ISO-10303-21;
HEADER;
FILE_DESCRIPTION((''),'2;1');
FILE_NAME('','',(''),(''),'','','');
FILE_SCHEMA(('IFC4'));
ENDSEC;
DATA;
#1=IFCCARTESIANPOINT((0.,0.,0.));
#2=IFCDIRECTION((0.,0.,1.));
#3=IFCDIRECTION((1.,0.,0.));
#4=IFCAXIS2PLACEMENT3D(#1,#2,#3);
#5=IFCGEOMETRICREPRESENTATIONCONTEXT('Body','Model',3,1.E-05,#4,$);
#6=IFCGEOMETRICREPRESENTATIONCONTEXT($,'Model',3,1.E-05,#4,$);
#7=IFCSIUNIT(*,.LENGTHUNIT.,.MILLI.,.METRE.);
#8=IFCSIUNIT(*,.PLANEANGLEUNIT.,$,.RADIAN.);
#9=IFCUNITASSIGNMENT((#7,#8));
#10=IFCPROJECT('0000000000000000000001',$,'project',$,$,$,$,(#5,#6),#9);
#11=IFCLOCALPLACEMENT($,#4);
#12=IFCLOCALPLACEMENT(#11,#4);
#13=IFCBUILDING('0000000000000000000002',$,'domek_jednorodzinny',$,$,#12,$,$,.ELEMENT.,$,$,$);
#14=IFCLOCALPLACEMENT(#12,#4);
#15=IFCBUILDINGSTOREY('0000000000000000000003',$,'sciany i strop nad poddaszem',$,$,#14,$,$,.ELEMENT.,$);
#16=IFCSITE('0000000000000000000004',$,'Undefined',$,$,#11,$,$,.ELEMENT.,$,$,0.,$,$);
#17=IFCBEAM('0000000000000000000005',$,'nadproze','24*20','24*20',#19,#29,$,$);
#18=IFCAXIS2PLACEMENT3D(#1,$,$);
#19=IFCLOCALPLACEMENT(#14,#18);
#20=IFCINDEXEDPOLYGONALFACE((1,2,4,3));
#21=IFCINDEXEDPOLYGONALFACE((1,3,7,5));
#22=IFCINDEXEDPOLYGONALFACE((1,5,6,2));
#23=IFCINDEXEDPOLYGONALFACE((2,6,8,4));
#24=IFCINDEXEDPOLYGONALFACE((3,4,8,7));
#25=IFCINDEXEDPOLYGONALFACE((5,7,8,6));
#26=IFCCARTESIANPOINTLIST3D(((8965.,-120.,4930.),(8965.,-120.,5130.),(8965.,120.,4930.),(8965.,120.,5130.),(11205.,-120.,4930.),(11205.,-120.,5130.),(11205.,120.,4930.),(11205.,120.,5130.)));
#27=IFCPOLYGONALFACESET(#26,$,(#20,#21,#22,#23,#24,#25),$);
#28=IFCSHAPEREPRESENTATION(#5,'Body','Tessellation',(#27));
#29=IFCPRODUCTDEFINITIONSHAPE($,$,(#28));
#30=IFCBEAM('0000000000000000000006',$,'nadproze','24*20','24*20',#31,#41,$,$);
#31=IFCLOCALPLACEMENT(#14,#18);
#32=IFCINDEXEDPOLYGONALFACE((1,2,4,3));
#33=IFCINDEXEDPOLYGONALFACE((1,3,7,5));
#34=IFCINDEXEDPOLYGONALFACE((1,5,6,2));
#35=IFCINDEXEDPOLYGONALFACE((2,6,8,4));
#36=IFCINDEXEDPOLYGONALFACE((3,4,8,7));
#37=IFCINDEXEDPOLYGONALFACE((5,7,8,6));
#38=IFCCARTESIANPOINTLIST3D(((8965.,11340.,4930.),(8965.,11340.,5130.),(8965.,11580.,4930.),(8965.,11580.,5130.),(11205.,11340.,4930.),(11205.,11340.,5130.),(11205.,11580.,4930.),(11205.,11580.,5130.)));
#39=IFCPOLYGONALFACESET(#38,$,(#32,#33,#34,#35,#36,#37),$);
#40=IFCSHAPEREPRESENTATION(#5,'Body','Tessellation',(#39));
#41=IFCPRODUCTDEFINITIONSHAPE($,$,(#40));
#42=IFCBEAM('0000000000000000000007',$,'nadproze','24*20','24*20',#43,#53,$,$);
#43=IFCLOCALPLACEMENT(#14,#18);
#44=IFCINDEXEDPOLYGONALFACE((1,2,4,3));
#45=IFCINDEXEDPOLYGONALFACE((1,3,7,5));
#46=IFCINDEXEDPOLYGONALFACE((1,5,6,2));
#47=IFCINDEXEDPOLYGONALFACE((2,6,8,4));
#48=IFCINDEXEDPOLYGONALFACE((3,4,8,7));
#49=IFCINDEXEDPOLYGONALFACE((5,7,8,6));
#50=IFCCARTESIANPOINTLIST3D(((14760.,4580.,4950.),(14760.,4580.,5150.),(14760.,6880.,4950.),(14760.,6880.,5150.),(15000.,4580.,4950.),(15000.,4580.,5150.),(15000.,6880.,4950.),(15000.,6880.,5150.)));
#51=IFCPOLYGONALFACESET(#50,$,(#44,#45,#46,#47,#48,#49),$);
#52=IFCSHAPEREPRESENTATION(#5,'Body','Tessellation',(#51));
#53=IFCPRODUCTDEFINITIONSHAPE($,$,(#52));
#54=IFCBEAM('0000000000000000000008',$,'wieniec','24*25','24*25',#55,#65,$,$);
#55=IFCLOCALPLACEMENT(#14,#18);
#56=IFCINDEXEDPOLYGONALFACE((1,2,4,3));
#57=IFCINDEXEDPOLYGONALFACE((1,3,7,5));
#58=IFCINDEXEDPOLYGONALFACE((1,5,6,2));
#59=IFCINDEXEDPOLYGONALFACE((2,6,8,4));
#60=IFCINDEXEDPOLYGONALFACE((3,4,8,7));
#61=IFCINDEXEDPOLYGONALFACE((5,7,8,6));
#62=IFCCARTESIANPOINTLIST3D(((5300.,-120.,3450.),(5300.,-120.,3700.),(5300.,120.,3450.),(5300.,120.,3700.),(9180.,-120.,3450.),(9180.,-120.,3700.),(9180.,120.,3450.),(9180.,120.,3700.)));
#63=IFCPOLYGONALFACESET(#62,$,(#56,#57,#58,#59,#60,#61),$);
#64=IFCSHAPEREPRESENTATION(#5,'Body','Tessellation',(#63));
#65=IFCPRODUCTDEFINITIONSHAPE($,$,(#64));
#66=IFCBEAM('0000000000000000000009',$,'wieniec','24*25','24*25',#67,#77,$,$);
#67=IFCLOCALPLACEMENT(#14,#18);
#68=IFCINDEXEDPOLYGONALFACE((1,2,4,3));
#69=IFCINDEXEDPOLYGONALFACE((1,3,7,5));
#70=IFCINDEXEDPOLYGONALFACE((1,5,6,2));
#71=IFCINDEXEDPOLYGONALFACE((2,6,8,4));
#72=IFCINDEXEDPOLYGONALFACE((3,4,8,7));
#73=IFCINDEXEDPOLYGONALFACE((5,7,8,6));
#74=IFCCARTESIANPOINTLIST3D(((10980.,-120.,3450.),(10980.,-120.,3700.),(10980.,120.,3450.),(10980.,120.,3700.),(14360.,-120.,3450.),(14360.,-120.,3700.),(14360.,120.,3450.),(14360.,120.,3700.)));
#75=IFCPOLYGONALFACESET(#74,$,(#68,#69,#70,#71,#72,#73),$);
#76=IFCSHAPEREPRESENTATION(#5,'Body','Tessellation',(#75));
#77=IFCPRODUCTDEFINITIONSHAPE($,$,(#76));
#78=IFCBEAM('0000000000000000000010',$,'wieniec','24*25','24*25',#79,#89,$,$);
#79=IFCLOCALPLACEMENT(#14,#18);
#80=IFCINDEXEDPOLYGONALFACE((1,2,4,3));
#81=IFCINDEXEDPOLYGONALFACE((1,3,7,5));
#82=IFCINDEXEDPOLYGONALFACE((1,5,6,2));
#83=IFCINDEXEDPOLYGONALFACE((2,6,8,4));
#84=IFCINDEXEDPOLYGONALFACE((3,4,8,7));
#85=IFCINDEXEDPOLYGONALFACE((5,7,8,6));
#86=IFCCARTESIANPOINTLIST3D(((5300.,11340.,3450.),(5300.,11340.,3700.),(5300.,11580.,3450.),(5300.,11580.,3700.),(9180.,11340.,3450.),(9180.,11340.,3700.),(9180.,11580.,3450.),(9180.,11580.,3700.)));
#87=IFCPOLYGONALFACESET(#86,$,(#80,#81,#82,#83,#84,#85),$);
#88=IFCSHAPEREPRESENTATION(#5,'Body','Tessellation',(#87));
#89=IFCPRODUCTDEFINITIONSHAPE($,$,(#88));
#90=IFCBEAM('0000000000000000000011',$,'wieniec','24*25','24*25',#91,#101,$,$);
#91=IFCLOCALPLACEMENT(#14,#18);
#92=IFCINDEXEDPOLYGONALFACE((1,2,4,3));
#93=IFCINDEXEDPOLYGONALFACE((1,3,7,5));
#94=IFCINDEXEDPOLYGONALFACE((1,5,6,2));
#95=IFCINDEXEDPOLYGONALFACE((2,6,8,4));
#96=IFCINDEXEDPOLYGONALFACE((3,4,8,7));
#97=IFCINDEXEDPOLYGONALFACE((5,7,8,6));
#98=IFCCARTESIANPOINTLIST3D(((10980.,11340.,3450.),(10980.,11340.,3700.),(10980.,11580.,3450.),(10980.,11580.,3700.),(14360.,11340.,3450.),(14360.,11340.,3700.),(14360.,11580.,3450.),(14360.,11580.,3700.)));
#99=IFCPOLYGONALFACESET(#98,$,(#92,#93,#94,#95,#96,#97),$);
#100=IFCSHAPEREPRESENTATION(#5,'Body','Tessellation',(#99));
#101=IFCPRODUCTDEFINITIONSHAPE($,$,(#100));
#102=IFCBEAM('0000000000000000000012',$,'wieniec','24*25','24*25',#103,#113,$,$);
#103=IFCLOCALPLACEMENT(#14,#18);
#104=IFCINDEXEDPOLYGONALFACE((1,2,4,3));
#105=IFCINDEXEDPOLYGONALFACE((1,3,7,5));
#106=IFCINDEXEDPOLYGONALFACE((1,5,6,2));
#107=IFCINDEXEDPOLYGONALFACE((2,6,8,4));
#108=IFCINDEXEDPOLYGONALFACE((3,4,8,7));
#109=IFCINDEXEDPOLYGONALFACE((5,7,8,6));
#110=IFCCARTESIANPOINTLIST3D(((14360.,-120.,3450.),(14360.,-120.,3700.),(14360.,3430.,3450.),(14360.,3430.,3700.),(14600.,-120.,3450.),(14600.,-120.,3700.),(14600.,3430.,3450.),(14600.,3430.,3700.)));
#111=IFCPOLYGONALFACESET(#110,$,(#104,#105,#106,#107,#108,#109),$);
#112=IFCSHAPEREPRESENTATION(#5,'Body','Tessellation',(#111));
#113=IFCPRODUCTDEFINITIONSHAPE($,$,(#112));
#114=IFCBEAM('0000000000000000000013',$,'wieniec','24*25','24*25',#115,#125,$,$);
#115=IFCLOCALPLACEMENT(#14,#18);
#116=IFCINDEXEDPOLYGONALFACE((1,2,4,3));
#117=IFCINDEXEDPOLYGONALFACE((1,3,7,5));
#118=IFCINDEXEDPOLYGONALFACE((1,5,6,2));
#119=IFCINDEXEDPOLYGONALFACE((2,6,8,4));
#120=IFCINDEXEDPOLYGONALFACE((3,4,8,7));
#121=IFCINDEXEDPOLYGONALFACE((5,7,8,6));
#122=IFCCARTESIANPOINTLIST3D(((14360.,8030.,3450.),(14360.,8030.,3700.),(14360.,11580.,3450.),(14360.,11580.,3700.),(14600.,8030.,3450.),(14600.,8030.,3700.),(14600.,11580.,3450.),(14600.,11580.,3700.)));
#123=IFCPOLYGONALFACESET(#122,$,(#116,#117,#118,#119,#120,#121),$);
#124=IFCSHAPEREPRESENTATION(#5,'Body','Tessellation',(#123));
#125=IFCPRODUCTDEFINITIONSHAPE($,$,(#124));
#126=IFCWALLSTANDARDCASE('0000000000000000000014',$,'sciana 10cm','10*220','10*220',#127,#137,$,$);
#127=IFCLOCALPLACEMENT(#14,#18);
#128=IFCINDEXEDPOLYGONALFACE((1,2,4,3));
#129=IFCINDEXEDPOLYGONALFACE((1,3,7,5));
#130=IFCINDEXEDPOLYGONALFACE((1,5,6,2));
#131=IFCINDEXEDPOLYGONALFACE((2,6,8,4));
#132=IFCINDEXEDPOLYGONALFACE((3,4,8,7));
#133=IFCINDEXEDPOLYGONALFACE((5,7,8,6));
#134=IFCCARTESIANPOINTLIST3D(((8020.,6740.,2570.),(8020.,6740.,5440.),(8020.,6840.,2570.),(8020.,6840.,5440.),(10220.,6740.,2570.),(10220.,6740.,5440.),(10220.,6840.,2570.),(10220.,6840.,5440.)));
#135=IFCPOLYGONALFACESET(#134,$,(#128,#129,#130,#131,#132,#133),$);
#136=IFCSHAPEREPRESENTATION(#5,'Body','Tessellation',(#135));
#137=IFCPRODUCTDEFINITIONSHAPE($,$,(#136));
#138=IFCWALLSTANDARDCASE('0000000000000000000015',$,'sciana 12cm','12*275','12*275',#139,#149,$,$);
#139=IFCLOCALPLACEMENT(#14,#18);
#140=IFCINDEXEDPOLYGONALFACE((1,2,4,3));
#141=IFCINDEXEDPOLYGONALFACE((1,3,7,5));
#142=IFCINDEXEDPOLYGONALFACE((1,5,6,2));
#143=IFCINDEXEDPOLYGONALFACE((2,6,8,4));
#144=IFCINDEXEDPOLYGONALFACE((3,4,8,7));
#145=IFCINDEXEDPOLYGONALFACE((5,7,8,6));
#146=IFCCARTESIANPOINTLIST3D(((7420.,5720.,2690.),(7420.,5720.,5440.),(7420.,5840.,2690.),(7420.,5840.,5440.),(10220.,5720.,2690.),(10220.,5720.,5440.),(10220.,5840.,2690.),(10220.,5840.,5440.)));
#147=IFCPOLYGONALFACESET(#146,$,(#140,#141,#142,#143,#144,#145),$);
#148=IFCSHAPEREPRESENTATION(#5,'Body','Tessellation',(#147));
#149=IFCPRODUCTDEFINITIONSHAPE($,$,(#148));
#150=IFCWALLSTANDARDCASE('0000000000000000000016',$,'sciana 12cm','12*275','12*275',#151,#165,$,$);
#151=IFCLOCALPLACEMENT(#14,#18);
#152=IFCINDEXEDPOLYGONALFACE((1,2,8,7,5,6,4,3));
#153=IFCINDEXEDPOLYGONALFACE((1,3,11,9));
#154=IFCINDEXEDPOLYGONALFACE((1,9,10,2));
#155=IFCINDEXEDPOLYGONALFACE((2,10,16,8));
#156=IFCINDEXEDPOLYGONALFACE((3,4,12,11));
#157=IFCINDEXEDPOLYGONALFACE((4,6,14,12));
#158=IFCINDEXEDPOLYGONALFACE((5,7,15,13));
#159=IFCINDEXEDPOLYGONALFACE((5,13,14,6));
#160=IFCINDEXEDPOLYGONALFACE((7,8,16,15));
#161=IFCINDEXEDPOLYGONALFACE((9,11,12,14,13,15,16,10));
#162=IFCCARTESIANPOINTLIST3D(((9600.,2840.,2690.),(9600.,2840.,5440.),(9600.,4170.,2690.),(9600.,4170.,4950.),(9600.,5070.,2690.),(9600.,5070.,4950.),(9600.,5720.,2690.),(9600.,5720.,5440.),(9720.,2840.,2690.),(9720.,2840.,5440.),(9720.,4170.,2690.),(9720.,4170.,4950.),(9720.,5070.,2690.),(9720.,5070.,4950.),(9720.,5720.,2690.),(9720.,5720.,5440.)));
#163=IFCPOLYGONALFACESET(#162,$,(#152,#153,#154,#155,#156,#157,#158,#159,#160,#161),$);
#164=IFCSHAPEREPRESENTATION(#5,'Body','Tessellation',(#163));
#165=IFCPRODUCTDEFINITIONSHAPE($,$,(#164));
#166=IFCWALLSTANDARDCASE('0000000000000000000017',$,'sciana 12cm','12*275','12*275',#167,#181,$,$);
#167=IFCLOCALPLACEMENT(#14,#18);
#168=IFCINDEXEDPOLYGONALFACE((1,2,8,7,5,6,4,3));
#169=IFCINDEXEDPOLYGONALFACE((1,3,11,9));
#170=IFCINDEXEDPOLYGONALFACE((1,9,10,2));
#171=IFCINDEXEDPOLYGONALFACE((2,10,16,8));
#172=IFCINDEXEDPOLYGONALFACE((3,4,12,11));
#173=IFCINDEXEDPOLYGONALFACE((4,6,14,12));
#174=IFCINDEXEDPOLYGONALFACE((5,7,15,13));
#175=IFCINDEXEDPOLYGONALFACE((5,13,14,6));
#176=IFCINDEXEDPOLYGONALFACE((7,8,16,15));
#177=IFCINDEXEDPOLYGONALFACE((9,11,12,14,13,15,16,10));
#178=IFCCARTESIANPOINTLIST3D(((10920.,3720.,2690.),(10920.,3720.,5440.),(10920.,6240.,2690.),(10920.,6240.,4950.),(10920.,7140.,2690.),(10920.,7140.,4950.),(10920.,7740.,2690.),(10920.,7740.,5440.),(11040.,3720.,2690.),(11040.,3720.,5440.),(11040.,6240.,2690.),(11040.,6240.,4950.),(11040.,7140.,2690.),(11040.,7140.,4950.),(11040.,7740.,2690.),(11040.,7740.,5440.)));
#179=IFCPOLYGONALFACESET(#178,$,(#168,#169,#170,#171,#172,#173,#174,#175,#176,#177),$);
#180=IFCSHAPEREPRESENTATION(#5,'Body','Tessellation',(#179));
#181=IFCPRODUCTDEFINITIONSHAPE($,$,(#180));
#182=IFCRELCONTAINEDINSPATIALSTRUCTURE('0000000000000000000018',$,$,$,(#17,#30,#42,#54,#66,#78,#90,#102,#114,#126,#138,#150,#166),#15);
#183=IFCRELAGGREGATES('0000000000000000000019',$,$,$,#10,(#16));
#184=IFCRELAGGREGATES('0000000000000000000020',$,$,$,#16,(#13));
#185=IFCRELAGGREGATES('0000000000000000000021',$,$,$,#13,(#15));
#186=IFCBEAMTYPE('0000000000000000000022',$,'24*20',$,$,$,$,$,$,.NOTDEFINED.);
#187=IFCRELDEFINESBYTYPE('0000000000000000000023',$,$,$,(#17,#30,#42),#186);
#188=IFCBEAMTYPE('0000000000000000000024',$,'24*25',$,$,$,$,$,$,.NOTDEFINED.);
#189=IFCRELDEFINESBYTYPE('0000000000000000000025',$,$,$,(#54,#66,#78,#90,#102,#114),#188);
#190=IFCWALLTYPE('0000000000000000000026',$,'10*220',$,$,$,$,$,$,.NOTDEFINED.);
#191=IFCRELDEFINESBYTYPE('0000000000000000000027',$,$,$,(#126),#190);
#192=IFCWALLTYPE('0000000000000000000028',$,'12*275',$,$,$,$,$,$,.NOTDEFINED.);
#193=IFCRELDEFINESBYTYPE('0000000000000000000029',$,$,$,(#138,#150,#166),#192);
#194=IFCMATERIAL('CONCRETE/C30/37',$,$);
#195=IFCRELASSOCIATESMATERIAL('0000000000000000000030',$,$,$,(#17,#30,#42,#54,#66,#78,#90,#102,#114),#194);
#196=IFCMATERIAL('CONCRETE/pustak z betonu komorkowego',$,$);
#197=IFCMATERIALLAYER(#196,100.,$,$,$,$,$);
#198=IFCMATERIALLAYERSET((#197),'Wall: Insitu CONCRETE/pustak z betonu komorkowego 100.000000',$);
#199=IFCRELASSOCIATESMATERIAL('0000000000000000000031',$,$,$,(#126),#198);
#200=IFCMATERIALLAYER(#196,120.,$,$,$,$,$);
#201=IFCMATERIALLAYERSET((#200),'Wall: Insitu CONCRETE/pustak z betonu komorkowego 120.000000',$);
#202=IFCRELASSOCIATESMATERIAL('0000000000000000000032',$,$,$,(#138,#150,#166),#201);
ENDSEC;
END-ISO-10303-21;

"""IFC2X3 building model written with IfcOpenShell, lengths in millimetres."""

from ifc_helpers import new_model, si_unit, frame, frame_2d, origin_with_axes, origin_2d_with_axis, place, context, project, spatial, polyline, rectangle, outline, extrude, material, layer, layer_set, layer_usage, type_object, element, save


model = new_model("IFC2X3")

# Units and contexts
model_context_1 = context("Model", 3, precision=1e-05, world=origin_with_axes(), identifier="Body")
model_context_2 = context("Model", 3, precision=1e-05, world=origin_with_axes())
ifc_project = project(units=[si_unit("LENGTHUNIT", "METRE", prefix="MILLI"), si_unit("PLANEANGLEUNIT", "RADIAN")], contexts=[model_context_1, model_context_2])

# Site, building, storey
site_placement = place(None, origin_with_axes())
site = spatial("IfcSite", under=ifc_project, at=site_placement, Name="Undefined", CompositionType="ELEMENT", RefElevation=0.0)
building_placement = place(site_placement, origin_with_axes())
building = spatial("IfcBuilding", under=site, at=building_placement, Name="domek_jednorodzinny", CompositionType="ELEMENT")
storey_placement = place(building_placement, origin_with_axes())
storey = spatial("IfcBuildingStorey", under=building, at=storey_placement, Name="sciany i strop nad poddaszem", CompositionType="ELEMENT")

# Beams
ifc_material_1 = material(Name="CONCRETE/C30/37")
beam_type_1 = type_object("IfcBeamType", Name="24*20", PredefinedType="NOTDEFINED")
for number, where, z_axis, x_axis, name in (
    (1, (8965.0, 0.0, 5030.0), (0.0, 0.0, 1.0), (1.0, 0.0, 0.0), "nadproze"),
    (2, (8965.0, 11460.0, 5030.0), (0.0, 0.0, 1.0), (1.0, 0.0, 0.0), "nadproze"),
):
    element("IfcBeam", number, at=place(storey_placement, frame(where, z_axis=z_axis, x_axis=x_axis)), inside=storey, type_object=beam_type_1, material=ifc_material_1, Name=name, Description="24*20", ObjectType="24*20", context=model_context_1, shape_type="SweptSolid", body=[
        extrude(rectangle(XDim=240.0, YDim=200.0, at=origin_2d_with_axis()), frame((2240.0, 0.0, 0.0), z_axis=(-1.0, 0.0, 0.0), x_axis=(0.0, -1.0, 0.0)), (0.0, 0.0, 1.0), 2240.0),
    ])
beam_1_placement = place(storey_placement, frame((14880.0, 6880.0, 5050.0), z_axis=(0.0, 0.0, 1.0), x_axis=(0.0, -1.0, 0.0)))
element("IfcBeam", 3, at=beam_1_placement, inside=storey, type_object=beam_type_1, material=ifc_material_1, Name="nadproze", Description="24*20", ObjectType="24*20", context=model_context_1, shape_type="SweptSolid", body=[
    extrude(rectangle(XDim=240.0, YDim=200.0, at=origin_2d_with_axis()), frame((2300.0, 0.0, 0.0), z_axis=(-1.0, 0.0, 0.0), x_axis=(0.0, -1.0, 0.0)), (0.0, 0.0, 1.0), 2300.0),
])
beam_type_2 = type_object("IfcBeamType", Name="24*25", PredefinedType="NOTDEFINED")
beam_2_placement = place(storey_placement, frame((9180.0, 0.0, 3575.0), z_axis=(0.0, 0.0, 1.0), x_axis=(-1.0, 0.0, 0.0)))
element("IfcBeam", 4, at=beam_2_placement, inside=storey, type_object=beam_type_2, material=ifc_material_1, Name="wieniec", Description="24*25", ObjectType="24*25", context=model_context_1, shape_type="SweptSolid", body=[
    extrude(rectangle(XDim=240.0, YDim=250.0, at=origin_2d_with_axis()), frame((3880.0, 0.0, 0.0), z_axis=(-1.0, 0.0, 0.0), x_axis=(0.0, -1.0, 0.0)), (0.0, 0.0, 1.0), 3880.0),
])
beam_3_placement = place(storey_placement, frame((14360.0, 0.0, 3575.0), z_axis=(0.0, 0.0, 1.0), x_axis=(-1.0, 0.0, 0.0)))
element("IfcBeam", 5, at=beam_3_placement, inside=storey, type_object=beam_type_2, material=ifc_material_1, Name="wieniec", Description="24*25", ObjectType="24*25", context=model_context_1, shape_type="SweptSolid", body=[
    extrude(rectangle(XDim=240.0, YDim=250.0, at=origin_2d_with_axis()), frame((3380.0, 0.0, 0.0), z_axis=(-1.0, 0.0, 0.0), x_axis=(0.0, -1.0, 0.0)), (0.0, 0.0, 1.0), 3380.0),
])
beam_4_placement = place(storey_placement, frame((9180.0, 11460.0, 3575.0), z_axis=(0.0, 0.0, 1.0), x_axis=(-1.0, 0.0, 0.0)))
element("IfcBeam", 6, at=beam_4_placement, inside=storey, type_object=beam_type_2, material=ifc_material_1, Name="wieniec", Description="24*25", ObjectType="24*25", context=model_context_1, shape_type="SweptSolid", body=[
    extrude(rectangle(XDim=240.0, YDim=250.0, at=origin_2d_with_axis()), frame((3880.0, 0.0, 0.0), z_axis=(-1.0, 0.0, 0.0), x_axis=(0.0, -1.0, 0.0)), (0.0, 0.0, 1.0), 3880.0),
])
beam_5_placement = place(storey_placement, frame((14360.0, 11460.0, 3575.0), z_axis=(0.0, 0.0, 1.0), x_axis=(-1.0, 0.0, 0.0)))
element("IfcBeam", 7, at=beam_5_placement, inside=storey, type_object=beam_type_2, material=ifc_material_1, Name="wieniec", Description="24*25", ObjectType="24*25", context=model_context_1, shape_type="SweptSolid", body=[
    extrude(rectangle(XDim=240.0, YDim=250.0, at=origin_2d_with_axis()), frame((3380.0, 0.0, 0.0), z_axis=(-1.0, 0.0, 0.0), x_axis=(0.0, -1.0, 0.0)), (0.0, 0.0, 1.0), 3380.0),
])
for number, where, z_axis, x_axis, name in (
    (8, (14480.0, 3430.0, 3575.0), (0.0, 0.0, 1.0), (0.0, -1.0, 0.0), "wieniec"),
    (9, (14480.0, 11580.0, 3575.0), (0.0, 0.0, 1.0), (0.0, -1.0, 0.0), "wieniec"),
):
    element("IfcBeam", number, at=place(storey_placement, frame(where, z_axis=z_axis, x_axis=x_axis)), inside=storey, type_object=beam_type_2, material=ifc_material_1, Name=name, Description="24*25", ObjectType="24*25", context=model_context_1, shape_type="SweptSolid", body=[
        extrude(rectangle(XDim=240.0, YDim=250.0, at=origin_2d_with_axis()), frame((3550.0, 0.0, 0.0), z_axis=(-1.0, 0.0, 0.0), x_axis=(0.0, -1.0, 0.0)), (0.0, 0.0, 1.0), 3550.0),
    ])

# Walls
ifc_material_2 = material(Name="CONCRETE/pustak z betonu komorkowego")
ifc_layer_1 = layer(ifc_material_2, 100.0)
ifc_layer_set_1 = layer_set([ifc_layer_1], Name="Wall: Insitu CONCRETE/pustak z betonu komorkowego 100.000000")
ifc_layer_usage_1 = layer_usage(ifc_layer_set_1, "AXIS2", "POSITIVE", -50.0)
wall_type_1 = type_object("IfcWallType", Name="10*220", PredefinedType="NOTDEFINED")
wall_1_placement = place(storey_placement, frame((10220.0, 6790.0, 2570.0), z_axis=(0.0, 0.0, 1.0), x_axis=(-1.0, 0.0, 0.0)))
element("IfcWallStandardCase", 10, at=wall_1_placement, inside=storey, type_object=wall_type_1, material=ifc_layer_usage_1, Name="sciana 10cm", Description="10*220", ObjectType="10*220", context=model_context_1, shape_type="SweptSolid", body=[
    extrude(rectangle(XDim=2200.0, YDim=100.0, at=frame_2d((0.0, 1100.0), x_axis=(0.0, -1.0))), frame((0.0, 0.0, 0.0), z_axis=(0.0, 0.0, 1.0), x_axis=(0.0, -1.0, 0.0)), (0.0, 0.0, 1.0), 2870.0),
])
ifc_layer_2 = layer(ifc_material_2, 120.0)
ifc_layer_set_2 = layer_set([ifc_layer_2], Name="Wall: Insitu CONCRETE/pustak z betonu komorkowego 120.000000")
ifc_layer_usage_2 = layer_usage(ifc_layer_set_2, "AXIS2", "POSITIVE", -60.0)
wall_type_2 = type_object("IfcWallType", Name="12*275", PredefinedType="NOTDEFINED")
wall_2_placement = place(storey_placement, frame((10220.0, 5780.0, 2690.0), z_axis=(0.0, 0.0, 1.0), x_axis=(-1.0, 0.0, 0.0)))
element("IfcWallStandardCase", 11, at=wall_2_placement, inside=storey, type_object=wall_type_2, material=ifc_layer_usage_2, Name="sciana 12cm", Description="12*275", ObjectType="12*275", context=model_context_1, shape_type="SweptSolid", body=[
    extrude(rectangle(XDim=2800.0, YDim=120.0, at=frame_2d((0.0, 1400.0), x_axis=(0.0, -1.0))), frame((0.0, 0.0, 0.0), z_axis=(0.0, 0.0, 1.0), x_axis=(0.0, -1.0, 0.0)), (0.0, 0.0, 1.0), 2750.0),
])

# Walls, openings
ifc_layer_usage_3 = layer_usage(ifc_layer_set_2, "AXIS2", "POSITIVE", -60.0)
wall_3_placement = place(storey_placement, frame((9660.0, 2840.0, 2690.0), z_axis=(0.0, 0.0, 1.0), x_axis=(0.0, 1.0, 0.0)))
wall_3 = element("IfcWallStandardCase", 12, at=wall_3_placement, inside=storey, type_object=wall_type_2, material=ifc_layer_usage_3, Name="sciana 12cm", Description="12*275", ObjectType="12*275", context=model_context_1, shape_type="SweptSolid", body=[
    extrude(rectangle(XDim=2880.0, YDim=120.0, at=frame_2d((0.0, 1440.0), x_axis=(0.0, -1.0))), frame((0.0, 0.0, 0.0), z_axis=(0.0, 0.0, 1.0), x_axis=(0.0, -1.0, 0.0)), (0.0, 0.0, 1.0), 2750.0),
])
opening_1_placement = place(storey_placement, frame((9660.0, 2840.0, 2690.0), z_axis=(0.0, 0.0, 1.0), x_axis=(0.0, 1.0, 0.0)))
element("IfcOpeningElement", 13, at=opening_1_placement, cuts=wall_3, ObjectType="Recess", context=model_context_1, shape_type="SweptSolid", body=[
    extrude(outline(polyline([(0.0, 0.0), (520.0, 0.0), (520.0, 900.0), (0.0, 900.0), (0.0, 0.0)])), frame((1330.0, -260.0, 2260.0), z_axis=(0.000001, 0.000001, -1.0), x_axis=(0.0, 1.0, 0.0)), (0.0, 0.0, 1.0), 2260.0),
])
ifc_layer_usage_4 = layer_usage(ifc_layer_set_2, "AXIS2", "POSITIVE", -60.0)
wall_4_placement = place(storey_placement, frame((10980.0, 3720.0, 2690.0), z_axis=(0.0, 0.0, 1.0), x_axis=(0.0, 1.0, 0.0)))
wall_4 = element("IfcWallStandardCase", 14, at=wall_4_placement, inside=storey, type_object=wall_type_2, material=ifc_layer_usage_4, Name="sciana 12cm", Description="12*275", ObjectType="12*275", context=model_context_1, shape_type="SweptSolid", body=[
    extrude(rectangle(XDim=4020.0, YDim=120.0, at=frame_2d((0.0, 2010.0), x_axis=(0.0, -1.0))), frame((0.0, 0.0, 0.0), z_axis=(0.0, 0.0, 1.0), x_axis=(0.0, -1.0, 0.0)), (0.0, 0.0, 1.0), 2750.0),
])
opening_2_placement = place(storey_placement, frame((10980.0, 3720.0, 2690.0), z_axis=(0.0, 0.0, 1.0), x_axis=(0.0, 1.0, 0.0)))
element("IfcOpeningElement", 15, at=opening_2_placement, cuts=wall_4, ObjectType="Recess", context=model_context_1, shape_type="SweptSolid", body=[
    extrude(outline(polyline([(0.0, 0.0), (520.0, 0.0), (520.0, 900.0), (0.0, 900.0), (0.0, 0.0)])), frame((2520.0, -260.0, 2260.0), z_axis=(0.000001, 0.000001, -1.0), x_axis=(0.0, 1.0, 0.0)), (0.0, 0.0, 1.0), 2260.0),
])

save(model, "model.ifc")
